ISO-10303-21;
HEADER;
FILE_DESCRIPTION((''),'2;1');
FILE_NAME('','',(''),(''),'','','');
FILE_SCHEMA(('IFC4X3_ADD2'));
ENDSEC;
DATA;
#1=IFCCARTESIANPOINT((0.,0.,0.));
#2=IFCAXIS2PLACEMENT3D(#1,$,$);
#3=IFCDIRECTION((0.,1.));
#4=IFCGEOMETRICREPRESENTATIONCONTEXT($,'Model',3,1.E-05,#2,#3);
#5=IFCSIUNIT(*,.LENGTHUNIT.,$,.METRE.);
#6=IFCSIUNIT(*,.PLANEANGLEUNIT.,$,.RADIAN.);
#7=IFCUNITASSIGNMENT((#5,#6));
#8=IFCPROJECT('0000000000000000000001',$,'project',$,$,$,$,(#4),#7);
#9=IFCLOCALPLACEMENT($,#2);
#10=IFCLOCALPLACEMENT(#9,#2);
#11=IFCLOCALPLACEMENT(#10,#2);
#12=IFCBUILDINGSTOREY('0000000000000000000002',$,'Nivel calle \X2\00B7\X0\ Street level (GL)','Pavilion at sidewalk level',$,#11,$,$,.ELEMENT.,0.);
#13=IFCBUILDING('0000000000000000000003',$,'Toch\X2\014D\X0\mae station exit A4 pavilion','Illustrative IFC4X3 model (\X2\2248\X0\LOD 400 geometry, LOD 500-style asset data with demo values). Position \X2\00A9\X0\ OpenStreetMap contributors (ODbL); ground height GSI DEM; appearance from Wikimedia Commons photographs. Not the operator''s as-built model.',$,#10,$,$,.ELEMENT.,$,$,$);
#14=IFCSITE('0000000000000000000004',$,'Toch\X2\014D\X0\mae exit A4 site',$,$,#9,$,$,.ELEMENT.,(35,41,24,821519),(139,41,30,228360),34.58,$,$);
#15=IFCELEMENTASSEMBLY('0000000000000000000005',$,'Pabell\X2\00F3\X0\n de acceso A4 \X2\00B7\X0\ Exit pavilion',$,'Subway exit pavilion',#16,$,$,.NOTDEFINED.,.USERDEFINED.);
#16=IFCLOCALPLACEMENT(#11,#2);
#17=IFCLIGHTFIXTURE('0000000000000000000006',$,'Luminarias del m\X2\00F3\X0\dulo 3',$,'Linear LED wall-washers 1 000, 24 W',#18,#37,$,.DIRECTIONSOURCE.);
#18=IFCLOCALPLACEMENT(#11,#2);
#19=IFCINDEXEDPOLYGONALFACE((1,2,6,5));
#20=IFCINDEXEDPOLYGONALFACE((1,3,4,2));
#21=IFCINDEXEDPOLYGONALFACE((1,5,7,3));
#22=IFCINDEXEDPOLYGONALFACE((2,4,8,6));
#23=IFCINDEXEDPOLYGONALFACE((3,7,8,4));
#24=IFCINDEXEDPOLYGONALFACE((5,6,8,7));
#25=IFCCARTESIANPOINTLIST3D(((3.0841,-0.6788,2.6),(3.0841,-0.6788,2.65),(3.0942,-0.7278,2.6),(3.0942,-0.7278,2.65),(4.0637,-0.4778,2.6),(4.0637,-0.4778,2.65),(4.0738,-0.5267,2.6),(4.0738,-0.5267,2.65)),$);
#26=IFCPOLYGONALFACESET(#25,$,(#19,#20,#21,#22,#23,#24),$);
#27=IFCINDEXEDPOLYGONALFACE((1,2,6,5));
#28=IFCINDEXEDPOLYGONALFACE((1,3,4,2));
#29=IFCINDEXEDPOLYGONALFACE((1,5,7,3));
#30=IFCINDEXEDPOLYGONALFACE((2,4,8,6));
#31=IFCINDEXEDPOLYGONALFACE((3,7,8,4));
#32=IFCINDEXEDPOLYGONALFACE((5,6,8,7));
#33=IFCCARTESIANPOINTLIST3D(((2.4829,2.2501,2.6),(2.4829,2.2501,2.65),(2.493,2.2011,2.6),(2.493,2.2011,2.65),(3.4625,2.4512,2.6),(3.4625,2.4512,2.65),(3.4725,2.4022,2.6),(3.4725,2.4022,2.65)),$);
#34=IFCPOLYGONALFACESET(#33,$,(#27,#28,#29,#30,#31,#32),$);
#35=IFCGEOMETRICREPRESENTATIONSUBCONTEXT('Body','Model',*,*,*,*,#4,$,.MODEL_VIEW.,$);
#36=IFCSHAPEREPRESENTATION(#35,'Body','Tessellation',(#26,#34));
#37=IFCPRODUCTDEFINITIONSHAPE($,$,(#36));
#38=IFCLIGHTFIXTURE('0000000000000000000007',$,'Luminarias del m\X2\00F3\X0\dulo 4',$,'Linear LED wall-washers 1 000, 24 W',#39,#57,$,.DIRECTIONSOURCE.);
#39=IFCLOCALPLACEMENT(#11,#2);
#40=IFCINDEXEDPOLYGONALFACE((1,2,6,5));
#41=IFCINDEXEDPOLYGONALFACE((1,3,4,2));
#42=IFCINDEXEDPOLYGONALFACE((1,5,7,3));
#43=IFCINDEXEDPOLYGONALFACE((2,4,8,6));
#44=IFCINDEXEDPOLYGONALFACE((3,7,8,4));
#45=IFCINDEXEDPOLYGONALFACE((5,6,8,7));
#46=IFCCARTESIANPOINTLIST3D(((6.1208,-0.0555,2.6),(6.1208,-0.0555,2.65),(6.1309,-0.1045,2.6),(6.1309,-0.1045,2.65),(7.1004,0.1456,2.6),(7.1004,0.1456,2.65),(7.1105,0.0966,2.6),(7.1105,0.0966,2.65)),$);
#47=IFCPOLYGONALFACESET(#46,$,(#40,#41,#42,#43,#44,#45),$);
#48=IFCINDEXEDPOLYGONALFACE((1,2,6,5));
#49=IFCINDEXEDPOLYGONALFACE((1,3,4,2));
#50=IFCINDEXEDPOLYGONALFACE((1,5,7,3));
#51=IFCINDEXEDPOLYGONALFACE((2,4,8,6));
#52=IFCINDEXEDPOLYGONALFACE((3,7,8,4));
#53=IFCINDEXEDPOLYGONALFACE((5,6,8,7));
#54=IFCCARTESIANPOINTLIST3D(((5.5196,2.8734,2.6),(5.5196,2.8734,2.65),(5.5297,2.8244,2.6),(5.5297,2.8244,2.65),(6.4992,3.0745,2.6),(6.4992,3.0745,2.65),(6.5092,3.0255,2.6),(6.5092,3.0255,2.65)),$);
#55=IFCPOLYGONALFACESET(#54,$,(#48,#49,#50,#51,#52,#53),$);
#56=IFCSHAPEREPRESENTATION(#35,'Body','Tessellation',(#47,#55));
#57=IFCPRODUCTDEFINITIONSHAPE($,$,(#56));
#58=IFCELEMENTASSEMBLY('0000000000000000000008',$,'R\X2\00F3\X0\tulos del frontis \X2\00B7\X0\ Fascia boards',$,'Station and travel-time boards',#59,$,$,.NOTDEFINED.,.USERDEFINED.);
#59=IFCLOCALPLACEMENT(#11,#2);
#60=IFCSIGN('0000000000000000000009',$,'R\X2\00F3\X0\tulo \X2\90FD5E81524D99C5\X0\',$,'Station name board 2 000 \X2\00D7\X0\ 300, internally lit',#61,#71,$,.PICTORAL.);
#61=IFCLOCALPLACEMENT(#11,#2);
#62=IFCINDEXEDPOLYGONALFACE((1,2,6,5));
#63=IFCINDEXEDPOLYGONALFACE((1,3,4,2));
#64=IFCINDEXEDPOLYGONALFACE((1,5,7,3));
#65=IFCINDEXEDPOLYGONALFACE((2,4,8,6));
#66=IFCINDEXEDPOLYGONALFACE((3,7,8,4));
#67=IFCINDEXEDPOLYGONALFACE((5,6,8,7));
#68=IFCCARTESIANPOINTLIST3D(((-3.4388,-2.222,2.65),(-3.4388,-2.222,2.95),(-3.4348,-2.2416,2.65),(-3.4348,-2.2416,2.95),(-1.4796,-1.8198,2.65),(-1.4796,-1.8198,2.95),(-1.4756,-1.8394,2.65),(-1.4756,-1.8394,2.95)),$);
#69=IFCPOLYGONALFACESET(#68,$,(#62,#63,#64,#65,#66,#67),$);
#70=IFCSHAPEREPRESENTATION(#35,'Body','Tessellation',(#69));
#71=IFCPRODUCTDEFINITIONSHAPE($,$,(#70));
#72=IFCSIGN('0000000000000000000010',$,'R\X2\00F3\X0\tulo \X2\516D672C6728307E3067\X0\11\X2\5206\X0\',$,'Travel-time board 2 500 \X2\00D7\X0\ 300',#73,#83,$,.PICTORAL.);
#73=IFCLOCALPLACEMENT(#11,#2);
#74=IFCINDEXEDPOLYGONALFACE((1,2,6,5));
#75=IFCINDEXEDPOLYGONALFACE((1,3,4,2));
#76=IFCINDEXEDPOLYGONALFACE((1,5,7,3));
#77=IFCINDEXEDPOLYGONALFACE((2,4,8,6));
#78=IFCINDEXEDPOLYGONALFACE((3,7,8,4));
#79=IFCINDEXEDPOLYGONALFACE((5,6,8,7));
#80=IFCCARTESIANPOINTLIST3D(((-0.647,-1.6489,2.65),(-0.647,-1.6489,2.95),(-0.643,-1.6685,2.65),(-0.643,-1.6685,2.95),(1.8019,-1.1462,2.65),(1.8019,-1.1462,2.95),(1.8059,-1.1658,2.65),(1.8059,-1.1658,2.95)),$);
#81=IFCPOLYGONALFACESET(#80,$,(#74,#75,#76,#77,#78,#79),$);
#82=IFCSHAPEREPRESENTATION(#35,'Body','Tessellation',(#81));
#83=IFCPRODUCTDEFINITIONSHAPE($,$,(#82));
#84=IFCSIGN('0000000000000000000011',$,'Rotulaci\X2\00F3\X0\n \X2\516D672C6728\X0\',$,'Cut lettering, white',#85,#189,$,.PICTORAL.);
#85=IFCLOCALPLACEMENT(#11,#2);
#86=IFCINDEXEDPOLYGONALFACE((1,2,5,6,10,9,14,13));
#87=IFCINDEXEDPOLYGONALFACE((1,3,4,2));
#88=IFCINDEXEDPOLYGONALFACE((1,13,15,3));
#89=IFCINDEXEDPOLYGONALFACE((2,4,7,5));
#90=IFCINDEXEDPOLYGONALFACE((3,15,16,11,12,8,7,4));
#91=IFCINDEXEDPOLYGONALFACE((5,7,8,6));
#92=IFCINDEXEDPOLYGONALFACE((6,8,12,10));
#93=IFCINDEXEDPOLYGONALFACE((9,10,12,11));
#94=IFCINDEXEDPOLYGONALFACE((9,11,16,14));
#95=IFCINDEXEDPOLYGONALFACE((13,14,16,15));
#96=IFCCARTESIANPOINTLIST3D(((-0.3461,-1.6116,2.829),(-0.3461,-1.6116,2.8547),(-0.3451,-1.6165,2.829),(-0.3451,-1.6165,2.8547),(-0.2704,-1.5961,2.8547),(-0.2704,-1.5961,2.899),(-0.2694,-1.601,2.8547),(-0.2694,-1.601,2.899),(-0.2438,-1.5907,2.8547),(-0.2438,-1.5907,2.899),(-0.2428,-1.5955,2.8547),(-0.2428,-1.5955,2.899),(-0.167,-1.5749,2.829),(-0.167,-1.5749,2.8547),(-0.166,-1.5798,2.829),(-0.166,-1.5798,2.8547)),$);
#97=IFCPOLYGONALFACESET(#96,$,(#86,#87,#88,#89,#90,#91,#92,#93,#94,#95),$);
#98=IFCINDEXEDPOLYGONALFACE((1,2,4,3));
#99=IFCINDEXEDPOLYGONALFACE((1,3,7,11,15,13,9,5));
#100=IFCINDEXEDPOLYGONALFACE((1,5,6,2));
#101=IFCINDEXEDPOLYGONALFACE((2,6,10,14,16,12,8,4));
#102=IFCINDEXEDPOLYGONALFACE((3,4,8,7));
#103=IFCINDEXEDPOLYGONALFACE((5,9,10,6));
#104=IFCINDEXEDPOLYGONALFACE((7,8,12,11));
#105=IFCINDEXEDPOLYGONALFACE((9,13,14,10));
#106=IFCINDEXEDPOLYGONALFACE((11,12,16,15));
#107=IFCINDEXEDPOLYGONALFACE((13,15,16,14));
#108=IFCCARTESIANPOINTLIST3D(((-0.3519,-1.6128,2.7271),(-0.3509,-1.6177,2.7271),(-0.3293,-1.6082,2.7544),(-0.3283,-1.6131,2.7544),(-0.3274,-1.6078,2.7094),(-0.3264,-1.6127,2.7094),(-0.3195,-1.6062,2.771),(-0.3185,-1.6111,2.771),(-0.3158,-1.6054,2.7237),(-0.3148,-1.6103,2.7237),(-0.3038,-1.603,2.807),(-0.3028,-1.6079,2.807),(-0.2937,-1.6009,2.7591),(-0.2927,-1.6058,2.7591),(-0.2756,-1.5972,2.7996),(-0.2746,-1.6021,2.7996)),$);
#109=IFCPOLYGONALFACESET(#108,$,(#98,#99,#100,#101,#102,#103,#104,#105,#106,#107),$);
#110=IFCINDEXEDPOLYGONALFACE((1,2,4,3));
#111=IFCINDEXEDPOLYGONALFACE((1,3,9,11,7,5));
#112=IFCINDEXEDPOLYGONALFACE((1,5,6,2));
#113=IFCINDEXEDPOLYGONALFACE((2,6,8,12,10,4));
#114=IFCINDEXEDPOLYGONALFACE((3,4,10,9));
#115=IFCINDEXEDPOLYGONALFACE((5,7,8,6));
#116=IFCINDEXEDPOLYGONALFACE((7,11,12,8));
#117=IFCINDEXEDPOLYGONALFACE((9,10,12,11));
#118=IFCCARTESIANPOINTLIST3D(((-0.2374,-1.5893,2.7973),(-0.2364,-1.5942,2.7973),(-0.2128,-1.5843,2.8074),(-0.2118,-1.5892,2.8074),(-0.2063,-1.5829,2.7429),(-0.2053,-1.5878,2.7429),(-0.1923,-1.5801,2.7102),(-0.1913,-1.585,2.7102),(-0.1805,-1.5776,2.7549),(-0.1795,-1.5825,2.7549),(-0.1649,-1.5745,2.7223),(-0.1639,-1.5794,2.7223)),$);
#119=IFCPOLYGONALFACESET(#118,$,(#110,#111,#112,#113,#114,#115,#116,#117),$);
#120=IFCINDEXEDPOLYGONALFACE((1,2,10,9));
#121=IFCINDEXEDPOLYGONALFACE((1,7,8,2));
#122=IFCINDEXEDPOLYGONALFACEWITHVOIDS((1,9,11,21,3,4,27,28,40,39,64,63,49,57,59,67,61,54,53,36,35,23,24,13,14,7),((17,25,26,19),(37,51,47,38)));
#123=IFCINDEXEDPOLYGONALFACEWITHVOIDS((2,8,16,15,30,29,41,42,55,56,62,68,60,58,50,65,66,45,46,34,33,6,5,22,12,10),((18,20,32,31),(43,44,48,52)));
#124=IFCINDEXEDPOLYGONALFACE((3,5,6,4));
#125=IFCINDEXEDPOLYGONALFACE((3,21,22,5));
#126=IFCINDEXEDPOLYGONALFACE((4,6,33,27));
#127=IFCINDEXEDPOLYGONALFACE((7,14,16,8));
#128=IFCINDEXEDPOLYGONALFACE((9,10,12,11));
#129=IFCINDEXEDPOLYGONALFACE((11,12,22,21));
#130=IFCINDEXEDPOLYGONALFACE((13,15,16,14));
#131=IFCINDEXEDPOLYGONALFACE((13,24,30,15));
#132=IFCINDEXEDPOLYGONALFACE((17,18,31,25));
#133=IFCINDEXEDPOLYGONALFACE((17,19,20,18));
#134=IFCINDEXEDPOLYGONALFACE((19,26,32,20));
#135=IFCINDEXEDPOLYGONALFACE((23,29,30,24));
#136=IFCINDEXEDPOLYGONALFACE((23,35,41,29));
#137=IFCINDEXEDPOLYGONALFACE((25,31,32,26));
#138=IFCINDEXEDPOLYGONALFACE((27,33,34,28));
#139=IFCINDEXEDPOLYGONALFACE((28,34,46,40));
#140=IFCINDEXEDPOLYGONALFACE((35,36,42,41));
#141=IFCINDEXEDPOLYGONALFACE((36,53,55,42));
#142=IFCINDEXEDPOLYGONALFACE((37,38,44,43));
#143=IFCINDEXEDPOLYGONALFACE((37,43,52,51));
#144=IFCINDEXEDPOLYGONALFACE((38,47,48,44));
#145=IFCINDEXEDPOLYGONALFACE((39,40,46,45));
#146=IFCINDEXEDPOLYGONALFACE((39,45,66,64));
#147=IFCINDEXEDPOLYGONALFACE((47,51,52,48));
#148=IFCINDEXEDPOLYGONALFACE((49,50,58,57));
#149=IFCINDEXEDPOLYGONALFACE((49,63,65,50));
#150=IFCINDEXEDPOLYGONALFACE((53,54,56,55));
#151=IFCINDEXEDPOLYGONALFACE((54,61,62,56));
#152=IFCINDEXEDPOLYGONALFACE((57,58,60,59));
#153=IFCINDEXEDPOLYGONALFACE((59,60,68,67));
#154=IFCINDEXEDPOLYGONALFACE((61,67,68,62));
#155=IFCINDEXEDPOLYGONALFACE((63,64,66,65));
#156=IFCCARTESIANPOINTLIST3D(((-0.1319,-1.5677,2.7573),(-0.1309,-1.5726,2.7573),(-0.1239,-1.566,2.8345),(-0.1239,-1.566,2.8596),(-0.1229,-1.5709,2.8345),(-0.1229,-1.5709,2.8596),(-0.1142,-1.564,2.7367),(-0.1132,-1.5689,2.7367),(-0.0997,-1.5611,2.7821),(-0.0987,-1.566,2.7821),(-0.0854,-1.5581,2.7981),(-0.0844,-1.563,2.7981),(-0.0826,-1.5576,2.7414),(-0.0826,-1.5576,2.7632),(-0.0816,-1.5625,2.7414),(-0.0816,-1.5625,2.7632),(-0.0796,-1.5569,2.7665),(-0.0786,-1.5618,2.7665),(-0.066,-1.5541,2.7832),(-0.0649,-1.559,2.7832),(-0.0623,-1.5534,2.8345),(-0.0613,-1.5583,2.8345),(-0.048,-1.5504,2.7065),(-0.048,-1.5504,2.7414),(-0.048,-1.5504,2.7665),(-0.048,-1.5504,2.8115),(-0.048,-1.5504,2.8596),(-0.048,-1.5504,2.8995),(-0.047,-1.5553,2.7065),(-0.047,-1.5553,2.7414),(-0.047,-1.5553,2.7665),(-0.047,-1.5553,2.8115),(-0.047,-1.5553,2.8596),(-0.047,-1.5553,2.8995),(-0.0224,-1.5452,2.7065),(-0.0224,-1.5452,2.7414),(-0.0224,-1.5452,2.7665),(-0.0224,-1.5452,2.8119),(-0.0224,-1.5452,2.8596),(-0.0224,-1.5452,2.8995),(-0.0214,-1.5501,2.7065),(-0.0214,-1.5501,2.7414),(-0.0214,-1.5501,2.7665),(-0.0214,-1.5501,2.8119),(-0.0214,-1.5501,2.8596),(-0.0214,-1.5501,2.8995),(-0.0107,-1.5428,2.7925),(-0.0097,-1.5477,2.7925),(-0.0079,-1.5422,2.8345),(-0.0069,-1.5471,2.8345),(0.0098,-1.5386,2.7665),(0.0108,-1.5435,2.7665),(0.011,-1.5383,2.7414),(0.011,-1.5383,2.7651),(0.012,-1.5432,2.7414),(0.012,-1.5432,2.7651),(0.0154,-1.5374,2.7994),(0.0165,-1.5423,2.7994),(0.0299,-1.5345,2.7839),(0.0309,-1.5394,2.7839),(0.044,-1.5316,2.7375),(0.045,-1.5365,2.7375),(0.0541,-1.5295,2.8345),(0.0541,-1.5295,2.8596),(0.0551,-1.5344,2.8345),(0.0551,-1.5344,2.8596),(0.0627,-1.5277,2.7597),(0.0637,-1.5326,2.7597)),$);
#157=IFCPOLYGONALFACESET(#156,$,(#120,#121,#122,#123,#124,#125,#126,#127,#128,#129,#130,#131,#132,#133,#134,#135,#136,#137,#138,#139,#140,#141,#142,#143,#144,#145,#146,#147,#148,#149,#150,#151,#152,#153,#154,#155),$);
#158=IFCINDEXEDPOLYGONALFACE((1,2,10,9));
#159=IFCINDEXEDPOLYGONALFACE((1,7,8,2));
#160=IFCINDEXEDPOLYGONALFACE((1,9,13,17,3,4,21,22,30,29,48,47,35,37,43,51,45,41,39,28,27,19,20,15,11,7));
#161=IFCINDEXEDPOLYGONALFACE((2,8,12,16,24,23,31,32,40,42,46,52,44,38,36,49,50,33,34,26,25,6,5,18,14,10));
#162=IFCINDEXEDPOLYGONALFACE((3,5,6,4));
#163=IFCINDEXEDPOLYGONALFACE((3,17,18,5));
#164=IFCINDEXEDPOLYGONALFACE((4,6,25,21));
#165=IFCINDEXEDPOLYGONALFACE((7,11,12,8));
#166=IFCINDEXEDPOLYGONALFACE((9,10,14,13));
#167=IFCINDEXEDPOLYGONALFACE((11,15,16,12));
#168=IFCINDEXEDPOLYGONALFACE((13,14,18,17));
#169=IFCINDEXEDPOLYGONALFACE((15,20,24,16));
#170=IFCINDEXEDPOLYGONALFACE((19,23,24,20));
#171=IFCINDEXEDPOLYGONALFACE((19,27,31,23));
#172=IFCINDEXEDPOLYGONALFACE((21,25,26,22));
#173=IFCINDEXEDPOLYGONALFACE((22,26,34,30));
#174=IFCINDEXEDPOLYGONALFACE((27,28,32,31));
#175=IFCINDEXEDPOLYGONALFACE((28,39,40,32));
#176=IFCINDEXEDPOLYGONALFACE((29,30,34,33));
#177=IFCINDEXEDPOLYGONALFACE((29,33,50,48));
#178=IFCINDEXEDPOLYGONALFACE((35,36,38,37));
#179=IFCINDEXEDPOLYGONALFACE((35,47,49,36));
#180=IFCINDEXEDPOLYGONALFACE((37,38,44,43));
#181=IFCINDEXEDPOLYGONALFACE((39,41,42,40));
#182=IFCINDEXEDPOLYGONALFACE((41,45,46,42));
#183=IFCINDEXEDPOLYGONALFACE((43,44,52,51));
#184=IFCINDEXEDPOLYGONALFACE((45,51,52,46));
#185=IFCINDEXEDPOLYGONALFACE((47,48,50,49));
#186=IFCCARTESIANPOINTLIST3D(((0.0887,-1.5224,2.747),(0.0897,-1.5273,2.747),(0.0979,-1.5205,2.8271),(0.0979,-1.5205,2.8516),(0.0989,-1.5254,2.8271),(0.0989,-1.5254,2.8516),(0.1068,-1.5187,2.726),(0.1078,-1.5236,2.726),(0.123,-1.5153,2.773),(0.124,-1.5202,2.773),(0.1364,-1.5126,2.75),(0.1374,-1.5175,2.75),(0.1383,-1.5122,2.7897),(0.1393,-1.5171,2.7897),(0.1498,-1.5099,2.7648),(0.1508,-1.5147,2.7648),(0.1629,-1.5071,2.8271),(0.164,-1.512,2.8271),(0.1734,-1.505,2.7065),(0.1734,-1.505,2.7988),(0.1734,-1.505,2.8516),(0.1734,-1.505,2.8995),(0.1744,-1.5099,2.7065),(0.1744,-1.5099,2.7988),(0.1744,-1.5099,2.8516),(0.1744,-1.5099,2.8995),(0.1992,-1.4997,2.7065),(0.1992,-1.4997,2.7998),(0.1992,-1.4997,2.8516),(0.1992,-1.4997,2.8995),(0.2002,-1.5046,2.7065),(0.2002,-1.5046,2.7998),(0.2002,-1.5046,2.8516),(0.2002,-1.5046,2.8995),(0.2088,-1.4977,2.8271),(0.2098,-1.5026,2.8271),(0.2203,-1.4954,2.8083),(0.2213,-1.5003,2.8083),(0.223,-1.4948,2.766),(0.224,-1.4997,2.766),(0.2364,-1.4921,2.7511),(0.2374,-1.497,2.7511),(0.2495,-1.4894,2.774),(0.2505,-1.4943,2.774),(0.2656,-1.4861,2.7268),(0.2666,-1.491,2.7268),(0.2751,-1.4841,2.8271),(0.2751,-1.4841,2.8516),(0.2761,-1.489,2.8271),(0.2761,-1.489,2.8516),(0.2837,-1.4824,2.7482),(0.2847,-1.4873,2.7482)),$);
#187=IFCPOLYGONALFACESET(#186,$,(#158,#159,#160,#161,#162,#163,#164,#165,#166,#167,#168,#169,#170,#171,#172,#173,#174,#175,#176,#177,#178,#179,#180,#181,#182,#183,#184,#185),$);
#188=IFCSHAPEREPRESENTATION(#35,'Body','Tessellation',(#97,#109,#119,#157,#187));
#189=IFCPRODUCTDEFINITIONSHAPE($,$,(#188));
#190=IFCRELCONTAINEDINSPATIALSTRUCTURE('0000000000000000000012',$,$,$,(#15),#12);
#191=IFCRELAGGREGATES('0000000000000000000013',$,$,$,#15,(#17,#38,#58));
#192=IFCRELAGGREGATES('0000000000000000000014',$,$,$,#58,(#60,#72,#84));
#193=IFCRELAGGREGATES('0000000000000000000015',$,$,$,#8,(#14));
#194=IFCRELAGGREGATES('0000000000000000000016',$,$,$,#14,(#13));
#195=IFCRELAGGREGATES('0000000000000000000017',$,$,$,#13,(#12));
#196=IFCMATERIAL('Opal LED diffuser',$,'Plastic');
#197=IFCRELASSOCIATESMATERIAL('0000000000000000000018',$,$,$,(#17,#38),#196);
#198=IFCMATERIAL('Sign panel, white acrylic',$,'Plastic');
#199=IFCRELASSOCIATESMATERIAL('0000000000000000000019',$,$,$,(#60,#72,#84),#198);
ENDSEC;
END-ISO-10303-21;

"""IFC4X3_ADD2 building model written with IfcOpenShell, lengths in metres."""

from ifc_helpers import new_model, si_unit, direction, frame, frame_2d, origin, place, context, subcontext, project, spatial, polyline, rectangle, outline, extrude, material, element, aggregate, save


model = new_model("IFC4X3_ADD2")

# Units and contexts
model_context = context("Model", 3, precision=1e-05, world=origin(), true_north=direction((0.0, 1.0)))
body_context = subcontext(model_context, "Body", "Model", "MODEL_VIEW")
ifc_project = project(units=[si_unit("LENGTHUNIT", "METRE"), si_unit("PLANEANGLEUNIT", "RADIAN")], contexts=[model_context])

# Site, building, storey
site_placement = place(None, origin())
site = spatial("IfcSite", under=ifc_project, at=site_placement, Name="Tochōmae exit A4 site", CompositionType="ELEMENT", RefLatitude=(35, 41, 24, 821519), RefLongitude=(139, 41, 30, 228360), RefElevation=34.58)
building_placement = place(site_placement, origin())
building = spatial("IfcBuilding", under=site, at=building_placement, Name="Tochōmae station exit A4 pavilion", Description="Illustrative IFC4X3 model (≈LOD 400 geometry, LOD 500-style asset data with demo values). Position © OpenStreetMap contributors (ODbL); ground height GSI DEM; appearance from Wikimedia Commons photographs. Not the operator's as-built model.", CompositionType="ELEMENT")
storey_placement = place(building_placement, origin())
storey = spatial("IfcBuildingStorey", under=building, at=storey_placement, Name="Nivel calle · Street level (GL)", Description="Pavilion at sidewalk level", CompositionType="ELEMENT", Elevation=0.0)

# Element assemblies, light fixtures, signs
assembly_1_placement = place(building_placement, origin())
assembly_1 = element("IfcElementAssembly", 1, at=assembly_1_placement, inside=storey, Name="Pabellón de acceso A4 · Exit pavilion", ObjectType="Subway exit pavilion", AssemblyPlace="NOTDEFINED", PredefinedType="USERDEFINED")
ifc_material_1 = material(Name="Opal LED diffuser", Category="Plastic")
light_fixture_1_placement = place(building_placement, origin())
light_fixture_1 = element("IfcLightFixture", 2, at=light_fixture_1_placement, material=ifc_material_1, Name="Luminarias del módulo 3", ObjectType="Linear LED wall-washers 1 000, 24 W", PredefinedType="DIRECTIONSOURCE", context=body_context, shape_type="SweptSolid", body=[
    extrude(rectangle(XDim=1.0, YDim=0.05, at=frame_2d((0.0, 0.0), x_axis=(0.979575, 0.201078))), frame((3.579, -0.6028, 2.6)), (0.0, 0.0, 1.0), 0.05),
    extrude(rectangle(XDim=1.0, YDim=0.05, at=frame_2d((0.0, 0.0), x_axis=(0.979575, 0.201078))), frame((2.9777, 2.3261, 2.6)), (0.0, 0.0, 1.0), 0.05),
])
light_fixture_2_placement = place(building_placement, origin())
light_fixture_2 = element("IfcLightFixture", 3, at=light_fixture_2_placement, material=ifc_material_1, Name="Luminarias del módulo 4", ObjectType="Linear LED wall-washers 1 000, 24 W", PredefinedType="DIRECTIONSOURCE", context=body_context, shape_type="SweptSolid", body=[
    extrude(rectangle(XDim=1.0, YDim=0.05, at=frame_2d((0.0, 0.0), x_axis=(0.979575, 0.201078))), frame((6.6156, 0.0205, 2.6)), (0.0, 0.0, 1.0), 0.05),
    extrude(rectangle(XDim=1.0, YDim=0.05, at=frame_2d((0.0, 0.0), x_axis=(0.979575, 0.201078))), frame((6.0144, 2.9495, 2.6)), (0.0, 0.0, 1.0), 0.05),
])
assembly_2_placement = place(building_placement, origin())
assembly_2 = element("IfcElementAssembly", 4, at=assembly_2_placement, Name="Rótulos del frontis · Fascia boards", ObjectType="Station and travel-time boards", AssemblyPlace="NOTDEFINED", PredefinedType="USERDEFINED")
aggregate(assembly_1, [light_fixture_1, light_fixture_2, assembly_2])
ifc_material_2 = material(Name="Sign panel, white acrylic", Category="Plastic")
sign_1_placement = place(building_placement, origin())
sign_1 = element("IfcSign", 5, at=sign_1_placement, material=ifc_material_2, Name="Rótulo 都庁前駅", ObjectType="Station name board 2 000 × 300, internally lit", PredefinedType="PICTORAL", context=body_context, shape_type="SweptSolid", body=[
    extrude(outline(polyline([(-1.0, 2.65), (1.0, 2.65), (1.0, 2.95), (-1.0, 2.95), (-1.0, 2.65)])), frame((-2.4592, -2.0209, 0.0), z_axis=(0.201078, -0.979575, 0.0), x_axis=(0.979575, 0.201078, 0.0)), (0.0, 0.0, 1.0), 0.02),
])
sign_2_placement = place(building_placement, origin())
sign_2 = element("IfcSign", 6, at=sign_2_placement, material=ifc_material_2, Name="Rótulo 六本木まで11分", ObjectType="Travel-time board 2 500 × 300", PredefinedType="PICTORAL", context=body_context, shape_type="SweptSolid", body=[
    extrude(outline(polyline([(-1.25, 2.65), (1.25, 2.65), (1.25, 2.95), (-1.25, 2.95), (-1.25, 2.65)])), frame((0.5775, -1.3976, 0.0), z_axis=(0.201078, -0.979575, 0.0), x_axis=(0.979575, 0.201078, 0.0)), (0.0, 0.0, 1.0), 0.02),
])
sign_3_placement = place(building_placement, origin())
sign_3 = element("IfcSign", 7, at=sign_3_placement, material=ifc_material_2, Name="Rotulación 六本木", ObjectType="Cut lettering, white", PredefinedType="PICTORAL", context=body_context, shape_type="SweptSolid", body=[
    extrude(outline(polyline([(0.1157, 0.174), (0.1157, 0.1297), (0.1942, 0.1297), (0.1942, 0.104), (0.0113, 0.104), (0.0113, 0.1297), (0.0886, 0.1297), (0.0886, 0.174), (0.1157, 0.174)])), frame((-0.3572, -1.6139, 2.725), z_axis=(0.201078, -0.979575, 0.0), x_axis=(0.979575, 0.201078, 0.0)), (0.0, 0.0, 1.0), 0.005),
    extrude(outline(polyline([(0.0832, 0.0746), (0.0648, 0.0341), (0.0423, -0.0013), (0.0304, -0.0156), (0.0053, 0.0021), (0.0284, 0.0294), (0.0385, 0.046), (0.0545, 0.082), (0.0832, 0.0746)])), frame((-0.3572, -1.6139, 2.725), z_axis=(0.201078, -0.979575, 0.0), x_axis=(0.979575, 0.201078, 0.0)), (0.0, 0.0, 1.0), 0.005),
    extrude(outline(polyline([(0.1473, 0.0824), (0.1804, 0.0299), (0.1962, -0.0027), (0.1683, -0.0148), (0.154, 0.0179), (0.1223, 0.0723), (0.1473, 0.0824)])), frame((-0.3572, -1.6139, 2.725), z_axis=(0.201078, -0.979575, 0.0), x_axis=(0.979575, 0.201078, 0.0)), (0.0, 0.0, 1.0), 0.005),
    extrude(outline(polyline([(0.3417, 0.1346), (0.4198, 0.1346), (0.4198, 0.1095), (0.3565, 0.1095), (0.3804, 0.0744), (0.3951, 0.0589), (0.4286, 0.0347), (0.4095, 0.0125), (0.3758, 0.0401), (0.3758, 0.0164), (0.3417, 0.0164), (0.3417, -0.0185), (0.3156, -0.0185), (0.3156, 0.0164), (0.2803, 0.0164), (0.2803, 0.0382), (0.248, 0.0117), (0.2299, 0.0323), (0.2629, 0.0571), (0.2774, 0.0731), (0.301, 0.1095), (0.2382, 0.1095), (0.2382, 0.1346), (0.3156, 0.1346), (0.3156, 0.1745), (0.3417, 0.1745), (0.3417, 0.1346)]), holes=[polyline([(0.3746, 0.0415), (0.3537, 0.0675), (0.3417, 0.0869), (0.3417, 0.0415), (0.3746, 0.0415)]), polyline([(0.3156, 0.0865), (0.2973, 0.0582), (0.2834, 0.0415), (0.3156, 0.0415), (0.3156, 0.0865)])]), frame((-0.3572, -1.6139, 2.725), z_axis=(0.201078, -0.979575, 0.0), x_axis=(0.979575, 0.201078, 0.0)), (0.0, 0.0, 1.0), 0.005),
    extrude(outline(polyline([(0.5416, 0.1745), (0.5679, 0.1745), (0.5679, 0.1266), (0.6454, 0.1266), (0.6454, 0.1021), (0.5778, 0.1021), (0.5895, 0.0833), (0.6194, 0.049), (0.6542, 0.0232), (0.6358, 0.0018), (0.606, 0.0261), (0.5923, 0.041), (0.5679, 0.0748), (0.5679, -0.0185), (0.5416, -0.0185), (0.5416, 0.0738), (0.5175, 0.0398), (0.5038, 0.025), (0.4736, 0.001), (0.4551, 0.022), (0.4902, 0.048), (0.5058, 0.0647), (0.531, 0.1021), (0.4646, 0.1021), (0.4646, 0.1266), (0.5416, 0.1266), (0.5416, 0.1745)])), frame((-0.3572, -1.6139, 2.725), z_axis=(0.201078, -0.979575, 0.0), x_axis=(0.979575, 0.201078, 0.0)), (0.0, 0.0, 1.0), 0.005),
])
aggregate(assembly_2, [sign_1, sign_2, sign_3])

save(model, "model.ifc")
